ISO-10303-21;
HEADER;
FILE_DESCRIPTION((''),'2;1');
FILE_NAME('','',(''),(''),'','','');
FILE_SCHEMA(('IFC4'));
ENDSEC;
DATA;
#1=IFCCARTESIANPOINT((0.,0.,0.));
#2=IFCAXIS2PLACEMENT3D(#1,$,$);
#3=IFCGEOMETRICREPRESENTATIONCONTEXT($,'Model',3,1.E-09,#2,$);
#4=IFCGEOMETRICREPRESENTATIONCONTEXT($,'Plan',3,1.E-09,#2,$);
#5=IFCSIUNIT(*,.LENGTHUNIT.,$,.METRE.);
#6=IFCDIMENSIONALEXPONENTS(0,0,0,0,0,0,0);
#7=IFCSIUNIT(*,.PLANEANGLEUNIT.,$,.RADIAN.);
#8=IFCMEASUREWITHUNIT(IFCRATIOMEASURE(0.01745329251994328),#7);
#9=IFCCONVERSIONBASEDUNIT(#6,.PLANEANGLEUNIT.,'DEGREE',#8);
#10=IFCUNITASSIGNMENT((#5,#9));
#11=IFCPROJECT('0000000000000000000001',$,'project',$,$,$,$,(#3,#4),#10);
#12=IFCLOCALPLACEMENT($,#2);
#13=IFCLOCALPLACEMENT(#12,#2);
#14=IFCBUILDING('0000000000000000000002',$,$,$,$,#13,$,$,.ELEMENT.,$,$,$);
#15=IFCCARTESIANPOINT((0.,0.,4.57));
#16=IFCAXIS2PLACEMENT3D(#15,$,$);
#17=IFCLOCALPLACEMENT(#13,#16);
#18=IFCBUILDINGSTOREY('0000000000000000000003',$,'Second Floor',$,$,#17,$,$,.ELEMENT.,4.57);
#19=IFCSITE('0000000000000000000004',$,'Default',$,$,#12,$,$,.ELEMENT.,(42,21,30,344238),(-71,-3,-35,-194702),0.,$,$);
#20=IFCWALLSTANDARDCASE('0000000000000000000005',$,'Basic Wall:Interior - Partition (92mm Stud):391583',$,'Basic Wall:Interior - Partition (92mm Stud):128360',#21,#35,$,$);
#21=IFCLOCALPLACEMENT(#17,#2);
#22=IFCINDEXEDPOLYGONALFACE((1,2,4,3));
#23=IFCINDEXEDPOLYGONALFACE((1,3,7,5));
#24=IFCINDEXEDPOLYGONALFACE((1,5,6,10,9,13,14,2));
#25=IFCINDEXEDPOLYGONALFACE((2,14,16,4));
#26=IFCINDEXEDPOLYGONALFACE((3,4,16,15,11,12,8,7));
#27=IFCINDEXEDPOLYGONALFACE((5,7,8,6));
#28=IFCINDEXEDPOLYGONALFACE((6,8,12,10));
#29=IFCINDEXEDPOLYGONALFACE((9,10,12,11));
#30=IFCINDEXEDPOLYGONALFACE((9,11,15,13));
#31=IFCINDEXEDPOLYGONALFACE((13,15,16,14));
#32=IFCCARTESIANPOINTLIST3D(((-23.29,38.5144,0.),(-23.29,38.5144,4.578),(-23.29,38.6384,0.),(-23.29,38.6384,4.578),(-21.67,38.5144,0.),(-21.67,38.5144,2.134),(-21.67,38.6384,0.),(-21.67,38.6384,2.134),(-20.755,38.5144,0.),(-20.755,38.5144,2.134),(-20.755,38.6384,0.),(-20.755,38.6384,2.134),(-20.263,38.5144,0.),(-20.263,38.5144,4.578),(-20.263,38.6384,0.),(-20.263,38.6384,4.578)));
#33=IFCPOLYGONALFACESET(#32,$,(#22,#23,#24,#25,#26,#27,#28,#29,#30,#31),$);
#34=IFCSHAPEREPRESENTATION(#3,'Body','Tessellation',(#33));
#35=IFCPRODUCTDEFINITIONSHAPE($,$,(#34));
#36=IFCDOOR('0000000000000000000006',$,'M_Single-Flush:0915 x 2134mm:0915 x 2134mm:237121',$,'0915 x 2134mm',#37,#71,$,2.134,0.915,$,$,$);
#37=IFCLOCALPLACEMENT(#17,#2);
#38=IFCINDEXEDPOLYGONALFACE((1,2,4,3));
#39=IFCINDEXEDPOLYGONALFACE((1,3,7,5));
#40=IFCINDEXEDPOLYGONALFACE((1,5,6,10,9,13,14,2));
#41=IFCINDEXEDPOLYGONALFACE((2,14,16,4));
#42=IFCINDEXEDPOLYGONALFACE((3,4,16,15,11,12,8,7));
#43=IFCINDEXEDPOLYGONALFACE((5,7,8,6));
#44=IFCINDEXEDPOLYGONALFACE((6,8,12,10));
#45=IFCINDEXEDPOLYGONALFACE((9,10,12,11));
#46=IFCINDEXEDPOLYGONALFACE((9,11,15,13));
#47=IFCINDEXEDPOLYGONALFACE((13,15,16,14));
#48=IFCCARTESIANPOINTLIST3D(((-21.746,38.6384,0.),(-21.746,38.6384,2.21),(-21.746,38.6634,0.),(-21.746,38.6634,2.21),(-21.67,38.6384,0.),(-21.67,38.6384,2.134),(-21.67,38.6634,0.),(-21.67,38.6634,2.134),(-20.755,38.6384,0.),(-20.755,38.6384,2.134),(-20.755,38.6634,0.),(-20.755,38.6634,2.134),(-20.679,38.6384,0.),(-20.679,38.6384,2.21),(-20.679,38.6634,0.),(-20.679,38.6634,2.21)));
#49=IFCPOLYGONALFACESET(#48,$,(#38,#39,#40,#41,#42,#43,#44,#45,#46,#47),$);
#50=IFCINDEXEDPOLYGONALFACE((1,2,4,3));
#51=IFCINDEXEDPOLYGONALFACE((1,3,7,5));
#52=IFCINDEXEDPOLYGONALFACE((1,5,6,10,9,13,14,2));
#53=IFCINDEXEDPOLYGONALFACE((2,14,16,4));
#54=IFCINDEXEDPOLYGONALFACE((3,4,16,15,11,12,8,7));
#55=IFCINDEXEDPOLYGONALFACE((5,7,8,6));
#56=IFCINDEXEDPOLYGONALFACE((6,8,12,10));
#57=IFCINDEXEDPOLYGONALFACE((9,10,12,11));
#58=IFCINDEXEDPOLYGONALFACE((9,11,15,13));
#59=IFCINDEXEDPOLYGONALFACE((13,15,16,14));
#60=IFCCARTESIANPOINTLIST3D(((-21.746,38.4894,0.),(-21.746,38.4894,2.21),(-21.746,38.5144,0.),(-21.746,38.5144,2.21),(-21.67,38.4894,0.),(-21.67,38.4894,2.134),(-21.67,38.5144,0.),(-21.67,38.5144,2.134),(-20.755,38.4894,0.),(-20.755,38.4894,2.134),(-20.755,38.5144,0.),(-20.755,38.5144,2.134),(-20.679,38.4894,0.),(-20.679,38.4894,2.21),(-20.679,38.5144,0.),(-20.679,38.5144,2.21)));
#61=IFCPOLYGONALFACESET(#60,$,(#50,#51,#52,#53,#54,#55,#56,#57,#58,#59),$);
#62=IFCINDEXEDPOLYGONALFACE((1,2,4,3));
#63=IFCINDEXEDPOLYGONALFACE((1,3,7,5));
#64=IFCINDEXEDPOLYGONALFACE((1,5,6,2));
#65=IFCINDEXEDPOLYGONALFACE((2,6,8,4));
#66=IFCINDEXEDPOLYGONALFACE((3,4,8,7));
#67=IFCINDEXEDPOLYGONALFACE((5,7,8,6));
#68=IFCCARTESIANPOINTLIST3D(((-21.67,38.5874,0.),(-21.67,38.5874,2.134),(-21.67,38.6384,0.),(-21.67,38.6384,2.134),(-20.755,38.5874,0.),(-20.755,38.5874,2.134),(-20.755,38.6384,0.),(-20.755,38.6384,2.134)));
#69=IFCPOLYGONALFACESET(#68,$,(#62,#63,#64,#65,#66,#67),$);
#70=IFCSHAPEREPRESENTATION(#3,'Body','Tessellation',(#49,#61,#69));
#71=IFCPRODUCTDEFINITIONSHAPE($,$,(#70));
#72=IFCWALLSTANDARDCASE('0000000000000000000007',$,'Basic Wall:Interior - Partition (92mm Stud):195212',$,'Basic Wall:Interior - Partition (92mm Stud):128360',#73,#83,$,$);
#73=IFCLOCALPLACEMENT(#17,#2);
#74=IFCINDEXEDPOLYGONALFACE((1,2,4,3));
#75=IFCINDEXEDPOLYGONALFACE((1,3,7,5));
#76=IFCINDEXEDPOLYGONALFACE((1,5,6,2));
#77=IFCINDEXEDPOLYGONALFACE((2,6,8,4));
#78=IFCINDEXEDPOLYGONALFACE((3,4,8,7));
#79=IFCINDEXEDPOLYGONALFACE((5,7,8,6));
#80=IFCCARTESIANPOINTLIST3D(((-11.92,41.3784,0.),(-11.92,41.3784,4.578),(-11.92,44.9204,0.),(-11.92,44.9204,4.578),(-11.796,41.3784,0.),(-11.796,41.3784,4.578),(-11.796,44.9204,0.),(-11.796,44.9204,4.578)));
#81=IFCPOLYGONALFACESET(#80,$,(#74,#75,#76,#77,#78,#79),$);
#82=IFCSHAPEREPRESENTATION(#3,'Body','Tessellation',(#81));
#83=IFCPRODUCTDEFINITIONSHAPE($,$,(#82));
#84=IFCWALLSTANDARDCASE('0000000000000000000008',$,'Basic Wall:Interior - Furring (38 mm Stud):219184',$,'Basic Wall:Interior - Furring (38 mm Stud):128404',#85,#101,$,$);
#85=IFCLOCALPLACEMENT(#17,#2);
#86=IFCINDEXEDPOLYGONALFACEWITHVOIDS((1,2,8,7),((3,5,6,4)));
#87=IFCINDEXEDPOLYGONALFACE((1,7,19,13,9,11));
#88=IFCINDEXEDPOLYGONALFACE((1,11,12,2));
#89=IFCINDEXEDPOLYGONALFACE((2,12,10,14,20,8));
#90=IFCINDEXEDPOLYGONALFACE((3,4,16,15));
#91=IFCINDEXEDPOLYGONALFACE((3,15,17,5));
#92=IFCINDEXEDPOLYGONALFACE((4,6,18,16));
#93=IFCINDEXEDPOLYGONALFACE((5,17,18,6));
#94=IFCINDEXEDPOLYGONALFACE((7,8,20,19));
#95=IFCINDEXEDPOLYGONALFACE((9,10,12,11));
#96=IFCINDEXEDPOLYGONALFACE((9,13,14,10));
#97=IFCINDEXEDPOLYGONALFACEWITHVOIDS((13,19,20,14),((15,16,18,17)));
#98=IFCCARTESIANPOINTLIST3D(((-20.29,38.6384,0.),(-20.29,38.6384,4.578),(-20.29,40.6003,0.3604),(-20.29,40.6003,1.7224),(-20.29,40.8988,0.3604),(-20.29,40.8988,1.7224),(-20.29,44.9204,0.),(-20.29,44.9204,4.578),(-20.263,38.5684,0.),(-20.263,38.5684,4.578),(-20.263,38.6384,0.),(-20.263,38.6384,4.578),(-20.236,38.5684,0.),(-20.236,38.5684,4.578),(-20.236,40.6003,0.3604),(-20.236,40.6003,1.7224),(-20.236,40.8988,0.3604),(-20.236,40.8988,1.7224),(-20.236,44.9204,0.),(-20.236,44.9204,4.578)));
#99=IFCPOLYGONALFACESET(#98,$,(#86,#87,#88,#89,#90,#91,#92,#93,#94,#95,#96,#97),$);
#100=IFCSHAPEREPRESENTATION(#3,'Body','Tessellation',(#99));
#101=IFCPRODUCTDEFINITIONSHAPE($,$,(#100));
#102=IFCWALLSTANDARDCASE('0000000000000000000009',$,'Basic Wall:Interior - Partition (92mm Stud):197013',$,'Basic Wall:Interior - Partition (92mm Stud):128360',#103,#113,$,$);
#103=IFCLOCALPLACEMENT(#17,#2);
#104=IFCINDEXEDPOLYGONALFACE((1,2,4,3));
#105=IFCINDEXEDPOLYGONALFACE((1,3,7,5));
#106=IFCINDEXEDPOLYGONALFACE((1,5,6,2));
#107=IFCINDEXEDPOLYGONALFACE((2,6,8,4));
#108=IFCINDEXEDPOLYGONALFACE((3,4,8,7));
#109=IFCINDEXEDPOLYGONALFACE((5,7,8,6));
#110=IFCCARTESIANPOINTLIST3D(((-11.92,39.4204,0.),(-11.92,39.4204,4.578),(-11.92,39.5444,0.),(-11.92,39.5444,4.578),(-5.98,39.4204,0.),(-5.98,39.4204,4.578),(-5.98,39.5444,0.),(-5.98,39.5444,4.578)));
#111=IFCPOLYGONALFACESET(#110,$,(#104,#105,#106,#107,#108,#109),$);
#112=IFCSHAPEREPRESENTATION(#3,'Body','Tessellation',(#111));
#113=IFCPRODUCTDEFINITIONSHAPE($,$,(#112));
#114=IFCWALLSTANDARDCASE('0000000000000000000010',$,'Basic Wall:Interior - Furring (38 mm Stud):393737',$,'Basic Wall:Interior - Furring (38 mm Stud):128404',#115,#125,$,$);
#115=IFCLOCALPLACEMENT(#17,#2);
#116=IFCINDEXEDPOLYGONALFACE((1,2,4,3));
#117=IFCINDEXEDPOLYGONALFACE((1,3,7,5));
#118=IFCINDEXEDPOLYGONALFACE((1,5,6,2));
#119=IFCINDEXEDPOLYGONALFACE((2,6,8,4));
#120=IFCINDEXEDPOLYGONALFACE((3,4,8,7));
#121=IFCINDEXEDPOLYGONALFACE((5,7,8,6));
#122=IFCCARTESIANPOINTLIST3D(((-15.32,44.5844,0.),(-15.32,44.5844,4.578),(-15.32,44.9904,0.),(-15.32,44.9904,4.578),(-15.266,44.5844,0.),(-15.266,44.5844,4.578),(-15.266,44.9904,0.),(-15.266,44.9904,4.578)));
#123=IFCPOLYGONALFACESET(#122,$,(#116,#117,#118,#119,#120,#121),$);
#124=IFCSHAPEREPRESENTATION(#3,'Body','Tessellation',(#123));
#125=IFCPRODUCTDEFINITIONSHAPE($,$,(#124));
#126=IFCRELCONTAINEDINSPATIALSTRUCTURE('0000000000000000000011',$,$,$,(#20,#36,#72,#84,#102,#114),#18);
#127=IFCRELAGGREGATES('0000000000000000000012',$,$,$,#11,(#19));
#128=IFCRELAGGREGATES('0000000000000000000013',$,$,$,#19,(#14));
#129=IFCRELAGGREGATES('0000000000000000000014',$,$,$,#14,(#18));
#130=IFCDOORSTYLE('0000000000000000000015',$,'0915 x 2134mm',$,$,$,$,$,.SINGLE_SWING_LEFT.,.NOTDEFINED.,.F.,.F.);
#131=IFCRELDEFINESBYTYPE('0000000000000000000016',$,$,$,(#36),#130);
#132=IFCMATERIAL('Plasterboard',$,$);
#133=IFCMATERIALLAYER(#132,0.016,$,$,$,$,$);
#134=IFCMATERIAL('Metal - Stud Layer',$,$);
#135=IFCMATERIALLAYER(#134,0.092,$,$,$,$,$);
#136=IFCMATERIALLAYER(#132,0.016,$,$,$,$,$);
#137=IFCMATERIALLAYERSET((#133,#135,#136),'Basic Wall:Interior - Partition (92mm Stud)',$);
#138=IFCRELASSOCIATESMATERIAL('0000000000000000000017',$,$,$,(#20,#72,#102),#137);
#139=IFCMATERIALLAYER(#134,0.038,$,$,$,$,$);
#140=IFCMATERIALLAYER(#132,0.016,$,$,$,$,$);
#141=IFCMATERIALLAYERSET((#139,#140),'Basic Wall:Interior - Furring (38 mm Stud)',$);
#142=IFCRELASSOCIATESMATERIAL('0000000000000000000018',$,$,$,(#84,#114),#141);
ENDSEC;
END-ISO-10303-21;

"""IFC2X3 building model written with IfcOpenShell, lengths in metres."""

from ifc_helpers import new_model, entity, si_unit, converted_unit, frame, frame_2d, origin, origin_2d_with_axis, place, context, project, spatial, polyline, rectangle, outline, extrude, source, transform, mapped, material, layer, layer_set, layer_usage, type_object, type_shapes, element, fill, save


model = new_model("IFC2X3")

# Units and contexts
model_context = context("Model", 3, precision=1e-09, world=origin())
plan_context = context("Plan", 3, precision=1e-09, world=origin())
ifc_project = project(units=[si_unit("LENGTHUNIT", "METRE"), converted_unit("PLANEANGLEUNIT", "DEGREE", entity("IfcRatioMeasure", 0.01745329251994328), si_unit("PLANEANGLEUNIT", "RADIAN"), dimensions=[0, 0, 0, 0, 0, 0, 0])], contexts=[model_context, plan_context])

# Site, building, storey
site_placement = place(None, origin())
site = spatial("IfcSite", under=ifc_project, at=site_placement, Name="Default", CompositionType="ELEMENT", RefLatitude=(42, 21, 30, 344238), RefLongitude=(-71, -3, -35, -194702), RefElevation=0.0)
building_placement = place(site_placement, origin())
building = spatial("IfcBuilding", under=site, at=building_placement, CompositionType="ELEMENT")
storey_placement = place(building_placement, frame((0.0, 0.0, 4.57)))
storey = spatial("IfcBuildingStorey", under=building, at=storey_placement, Name="Second Floor", CompositionType="ELEMENT", Elevation=4.57)

# Wall, opening, door
ifc_material_1 = material(Name="Plasterboard")
ifc_layer_1 = layer(ifc_material_1, 0.016)
ifc_material_2 = material(Name="Metal - Stud Layer")
ifc_layer_2 = layer(ifc_material_2, 0.092)
ifc_layer_3 = layer(ifc_material_1, 0.016)
ifc_layer_set_1 = layer_set([ifc_layer_1, ifc_layer_2, ifc_layer_3], Name="Basic Wall:Interior - Partition (92mm Stud)")
ifc_layer_usage_1 = layer_usage(ifc_layer_set_1, "AXIS2", "NEGATIVE", 0.062)
wall_1_placement = place(storey_placement, frame((-20.263, 38.5764, 0.0), z_axis=(0.0, 0.0, 1.0), x_axis=(-1.0, 0.0, 0.0)))
wall_1 = element("IfcWallStandardCase", 1, at=wall_1_placement, inside=storey, material=ifc_layer_usage_1, Name="Basic Wall:Interior - Partition (92mm Stud):391583", ObjectType="Basic Wall:Interior - Partition (92mm Stud):128360", context=model_context, shape_type="SweptSolid", body=[
    extrude(rectangle(XDim=3.027, YDim=0.124, at=frame_2d((1.5135, 0.0), x_axis=(-1.0, 0.0))), origin(), (0.0, 0.0, 1.0), 4.578),
])
opening_1_placement = place(wall_1_placement, frame((1.407, 0.062, 0.0)))
opening_1 = element("IfcOpeningElement", 2, at=opening_1_placement, cuts=wall_1, ObjectType="Opening", context=model_context, shape_type="SweptSolid", body=[
    extrude(rectangle(XDim=0.915, YDim=2.134, at=frame_2d((1.067, 0.4575), x_axis=(0.0, -1.0))), frame((0.0, 0.0, 0.0), z_axis=(0.0, -1.0, 0.0), x_axis=(0.0, 0.0, 1.0)), (0.0, 0.0, 1.0), 0.124),
])
door_style_1 = type_object("IfcDoorStyle", Name="0915 x 2134mm", ConstructionType="NOTDEFINED", OperationType="SINGLE_SWING_LEFT", ParameterTakesPrecedence=False, Sizeable=False)
shared_shape_1 = source(origin(), model_context, "Body", "SweptSolid", [
    extrude(outline(polyline([(-0.5335, -1.124), (0.5335, -1.124), (0.5335, 1.086), (0.4575, 1.086), (0.4575, -1.048), (-0.4575, -1.048), (-0.4575, 1.086), (-0.5335, 1.086), (-0.5335, -1.124)])), frame((0.4575, 0.149, 1.086), z_axis=(0.0, -1.0, 0.0), x_axis=(-1.0, 0.0, 0.0)), (0.0, 0.0, 1.0), 0.025),
    extrude(outline(polyline([(-1.124, -0.5335), (1.086, -0.5335), (1.086, -0.4575), (-1.048, -0.4575), (-1.048, 0.4575), (1.086, 0.4575), (1.086, 0.5335), (-1.124, 0.5335), (-1.124, -0.5335)])), frame((0.4575, 0.0, 1.086), z_axis=(0.0, -1.0, 0.0), x_axis=(0.0, 0.0, -1.0)), (0.0, 0.0, 1.0), 0.025),
    extrude(rectangle(XDim=0.915, YDim=0.051, at=origin_2d_with_axis()), frame((0.4575, 0.0985, 0.0)), (0.0, 0.0, 1.0), 2.134),
])
type_shapes(door_style_1, [shared_shape_1])
door_1_placement = place(opening_1_placement, frame((0.0, 0.0, 0.0), z_axis=(0.0, 0.0, 1.0), x_axis=(-1.0, 0.0, 0.0)))
door_1 = element("IfcDoor", 3, at=door_1_placement, inside=storey, type_object=door_style_1, Name="M_Single-Flush:0915 x 2134mm:0915 x 2134mm:237121", ObjectType="0915 x 2134mm", OverallHeight=2.134, OverallWidth=0.915, context=model_context, shape_type="MappedRepresentation", body=[
    mapped(shared_shape_1, transform((0.0, 0.0, 0.0), scale=1.0)),
])
fill(opening_1, door_1)

# Wall
wall_2_placement = place(storey_placement, frame((-11.858, 41.3784, 0.0), z_axis=(0.0, 0.0, 1.0), x_axis=(0.0, 1.0, 0.0)))
element("IfcWallStandardCase", 4, at=wall_2_placement, inside=storey, material=ifc_layer_usage_1, Name="Basic Wall:Interior - Partition (92mm Stud):195212", ObjectType="Basic Wall:Interior - Partition (92mm Stud):128360", context=model_context, shape_type="SweptSolid", body=[
    extrude(rectangle(XDim=3.542, YDim=0.124, at=frame_2d((1.771, 0.0), x_axis=(-1.0, 0.0))), origin(), (0.0, 0.0, 1.0), 4.578),
])

# Wall, opening
ifc_layer_4 = layer(ifc_material_2, 0.038)
ifc_layer_5 = layer(ifc_material_1, 0.016)
ifc_layer_set_2 = layer_set([ifc_layer_4, ifc_layer_5], Name="Basic Wall:Interior - Furring (38 mm Stud)")
ifc_layer_usage_2 = layer_usage(ifc_layer_set_2, "AXIS2", "POSITIVE", -0.027)
wall_3_placement = place(storey_placement, frame((-20.263, 38.5684, 0.0), z_axis=(0.0, 0.0, 1.0), x_axis=(0.0, 1.0, 0.0)))
wall_3 = element("IfcWallStandardCase", 5, at=wall_3_placement, inside=storey, material=ifc_layer_usage_2, Name="Basic Wall:Interior - Furring (38 mm Stud):219184", ObjectType="Basic Wall:Interior - Furring (38 mm Stud):128404", context=model_context, shape_type="SweptSolid", body=[
    extrude(outline(polyline([(6.3521, -0.027), (6.3521, 0.027), (3.0261, 0.027), (2.9021, 0.027), (0.07, 0.027), (0.07, 0.0), (0.0, 0.0), (0.0, -0.027), (6.3521, -0.027)])), origin(), (0.0, 0.0, 1.0), 4.578),
])
opening_2_placement = place(wall_3_placement, origin())
element("IfcOpeningElement", 6, at=opening_2_placement, cuts=wall_3, ObjectType="Opening", context=model_context, shape_type="SweptSolid", body=[
    extrude(rectangle(XDim=1.3621, YDim=0.2984, at=frame_2d((0.0, 0.0), x_axis=(0.0, 1.0))), frame((2.1812, -0.0619, 1.0414), z_axis=(0.0, 1.0, 0.0), x_axis=(1.0, 0.0, 0.0)), (0.0, 0.0, 1.0), 0.1524),
])

# Walls
wall_4_placement = place(storey_placement, frame((-11.92, 39.4824, 0.0)))
element("IfcWallStandardCase", 7, at=wall_4_placement, inside=storey, material=ifc_layer_usage_1, Name="Basic Wall:Interior - Partition (92mm Stud):197013", ObjectType="Basic Wall:Interior - Partition (92mm Stud):128360", context=model_context, shape_type="SweptSolid", body=[
    extrude(rectangle(XDim=5.94, YDim=0.124, at=frame_2d((2.97, 0.0), x_axis=(-1.0, 0.0))), origin(), (0.0, 0.0, 1.0), 4.578),
])
wall_5_placement = place(storey_placement, frame((-15.293, 44.5844, 0.0), z_axis=(0.0, 0.0, 1.0), x_axis=(0.0, 1.0, 0.0)))
element("IfcWallStandardCase", 8, at=wall_5_placement, inside=storey, material=ifc_layer_usage_2, Name="Basic Wall:Interior - Furring (38 mm Stud):393737", ObjectType="Basic Wall:Interior - Furring (38 mm Stud):128404", context=model_context, shape_type="SweptSolid", body=[
    extrude(rectangle(XDim=0.406, YDim=0.054, at=frame_2d((0.203, 0.0), x_axis=(-1.0, 0.0))), origin(), (0.0, 0.0, 1.0), 4.578),
])

save(model, "model.ifc")
